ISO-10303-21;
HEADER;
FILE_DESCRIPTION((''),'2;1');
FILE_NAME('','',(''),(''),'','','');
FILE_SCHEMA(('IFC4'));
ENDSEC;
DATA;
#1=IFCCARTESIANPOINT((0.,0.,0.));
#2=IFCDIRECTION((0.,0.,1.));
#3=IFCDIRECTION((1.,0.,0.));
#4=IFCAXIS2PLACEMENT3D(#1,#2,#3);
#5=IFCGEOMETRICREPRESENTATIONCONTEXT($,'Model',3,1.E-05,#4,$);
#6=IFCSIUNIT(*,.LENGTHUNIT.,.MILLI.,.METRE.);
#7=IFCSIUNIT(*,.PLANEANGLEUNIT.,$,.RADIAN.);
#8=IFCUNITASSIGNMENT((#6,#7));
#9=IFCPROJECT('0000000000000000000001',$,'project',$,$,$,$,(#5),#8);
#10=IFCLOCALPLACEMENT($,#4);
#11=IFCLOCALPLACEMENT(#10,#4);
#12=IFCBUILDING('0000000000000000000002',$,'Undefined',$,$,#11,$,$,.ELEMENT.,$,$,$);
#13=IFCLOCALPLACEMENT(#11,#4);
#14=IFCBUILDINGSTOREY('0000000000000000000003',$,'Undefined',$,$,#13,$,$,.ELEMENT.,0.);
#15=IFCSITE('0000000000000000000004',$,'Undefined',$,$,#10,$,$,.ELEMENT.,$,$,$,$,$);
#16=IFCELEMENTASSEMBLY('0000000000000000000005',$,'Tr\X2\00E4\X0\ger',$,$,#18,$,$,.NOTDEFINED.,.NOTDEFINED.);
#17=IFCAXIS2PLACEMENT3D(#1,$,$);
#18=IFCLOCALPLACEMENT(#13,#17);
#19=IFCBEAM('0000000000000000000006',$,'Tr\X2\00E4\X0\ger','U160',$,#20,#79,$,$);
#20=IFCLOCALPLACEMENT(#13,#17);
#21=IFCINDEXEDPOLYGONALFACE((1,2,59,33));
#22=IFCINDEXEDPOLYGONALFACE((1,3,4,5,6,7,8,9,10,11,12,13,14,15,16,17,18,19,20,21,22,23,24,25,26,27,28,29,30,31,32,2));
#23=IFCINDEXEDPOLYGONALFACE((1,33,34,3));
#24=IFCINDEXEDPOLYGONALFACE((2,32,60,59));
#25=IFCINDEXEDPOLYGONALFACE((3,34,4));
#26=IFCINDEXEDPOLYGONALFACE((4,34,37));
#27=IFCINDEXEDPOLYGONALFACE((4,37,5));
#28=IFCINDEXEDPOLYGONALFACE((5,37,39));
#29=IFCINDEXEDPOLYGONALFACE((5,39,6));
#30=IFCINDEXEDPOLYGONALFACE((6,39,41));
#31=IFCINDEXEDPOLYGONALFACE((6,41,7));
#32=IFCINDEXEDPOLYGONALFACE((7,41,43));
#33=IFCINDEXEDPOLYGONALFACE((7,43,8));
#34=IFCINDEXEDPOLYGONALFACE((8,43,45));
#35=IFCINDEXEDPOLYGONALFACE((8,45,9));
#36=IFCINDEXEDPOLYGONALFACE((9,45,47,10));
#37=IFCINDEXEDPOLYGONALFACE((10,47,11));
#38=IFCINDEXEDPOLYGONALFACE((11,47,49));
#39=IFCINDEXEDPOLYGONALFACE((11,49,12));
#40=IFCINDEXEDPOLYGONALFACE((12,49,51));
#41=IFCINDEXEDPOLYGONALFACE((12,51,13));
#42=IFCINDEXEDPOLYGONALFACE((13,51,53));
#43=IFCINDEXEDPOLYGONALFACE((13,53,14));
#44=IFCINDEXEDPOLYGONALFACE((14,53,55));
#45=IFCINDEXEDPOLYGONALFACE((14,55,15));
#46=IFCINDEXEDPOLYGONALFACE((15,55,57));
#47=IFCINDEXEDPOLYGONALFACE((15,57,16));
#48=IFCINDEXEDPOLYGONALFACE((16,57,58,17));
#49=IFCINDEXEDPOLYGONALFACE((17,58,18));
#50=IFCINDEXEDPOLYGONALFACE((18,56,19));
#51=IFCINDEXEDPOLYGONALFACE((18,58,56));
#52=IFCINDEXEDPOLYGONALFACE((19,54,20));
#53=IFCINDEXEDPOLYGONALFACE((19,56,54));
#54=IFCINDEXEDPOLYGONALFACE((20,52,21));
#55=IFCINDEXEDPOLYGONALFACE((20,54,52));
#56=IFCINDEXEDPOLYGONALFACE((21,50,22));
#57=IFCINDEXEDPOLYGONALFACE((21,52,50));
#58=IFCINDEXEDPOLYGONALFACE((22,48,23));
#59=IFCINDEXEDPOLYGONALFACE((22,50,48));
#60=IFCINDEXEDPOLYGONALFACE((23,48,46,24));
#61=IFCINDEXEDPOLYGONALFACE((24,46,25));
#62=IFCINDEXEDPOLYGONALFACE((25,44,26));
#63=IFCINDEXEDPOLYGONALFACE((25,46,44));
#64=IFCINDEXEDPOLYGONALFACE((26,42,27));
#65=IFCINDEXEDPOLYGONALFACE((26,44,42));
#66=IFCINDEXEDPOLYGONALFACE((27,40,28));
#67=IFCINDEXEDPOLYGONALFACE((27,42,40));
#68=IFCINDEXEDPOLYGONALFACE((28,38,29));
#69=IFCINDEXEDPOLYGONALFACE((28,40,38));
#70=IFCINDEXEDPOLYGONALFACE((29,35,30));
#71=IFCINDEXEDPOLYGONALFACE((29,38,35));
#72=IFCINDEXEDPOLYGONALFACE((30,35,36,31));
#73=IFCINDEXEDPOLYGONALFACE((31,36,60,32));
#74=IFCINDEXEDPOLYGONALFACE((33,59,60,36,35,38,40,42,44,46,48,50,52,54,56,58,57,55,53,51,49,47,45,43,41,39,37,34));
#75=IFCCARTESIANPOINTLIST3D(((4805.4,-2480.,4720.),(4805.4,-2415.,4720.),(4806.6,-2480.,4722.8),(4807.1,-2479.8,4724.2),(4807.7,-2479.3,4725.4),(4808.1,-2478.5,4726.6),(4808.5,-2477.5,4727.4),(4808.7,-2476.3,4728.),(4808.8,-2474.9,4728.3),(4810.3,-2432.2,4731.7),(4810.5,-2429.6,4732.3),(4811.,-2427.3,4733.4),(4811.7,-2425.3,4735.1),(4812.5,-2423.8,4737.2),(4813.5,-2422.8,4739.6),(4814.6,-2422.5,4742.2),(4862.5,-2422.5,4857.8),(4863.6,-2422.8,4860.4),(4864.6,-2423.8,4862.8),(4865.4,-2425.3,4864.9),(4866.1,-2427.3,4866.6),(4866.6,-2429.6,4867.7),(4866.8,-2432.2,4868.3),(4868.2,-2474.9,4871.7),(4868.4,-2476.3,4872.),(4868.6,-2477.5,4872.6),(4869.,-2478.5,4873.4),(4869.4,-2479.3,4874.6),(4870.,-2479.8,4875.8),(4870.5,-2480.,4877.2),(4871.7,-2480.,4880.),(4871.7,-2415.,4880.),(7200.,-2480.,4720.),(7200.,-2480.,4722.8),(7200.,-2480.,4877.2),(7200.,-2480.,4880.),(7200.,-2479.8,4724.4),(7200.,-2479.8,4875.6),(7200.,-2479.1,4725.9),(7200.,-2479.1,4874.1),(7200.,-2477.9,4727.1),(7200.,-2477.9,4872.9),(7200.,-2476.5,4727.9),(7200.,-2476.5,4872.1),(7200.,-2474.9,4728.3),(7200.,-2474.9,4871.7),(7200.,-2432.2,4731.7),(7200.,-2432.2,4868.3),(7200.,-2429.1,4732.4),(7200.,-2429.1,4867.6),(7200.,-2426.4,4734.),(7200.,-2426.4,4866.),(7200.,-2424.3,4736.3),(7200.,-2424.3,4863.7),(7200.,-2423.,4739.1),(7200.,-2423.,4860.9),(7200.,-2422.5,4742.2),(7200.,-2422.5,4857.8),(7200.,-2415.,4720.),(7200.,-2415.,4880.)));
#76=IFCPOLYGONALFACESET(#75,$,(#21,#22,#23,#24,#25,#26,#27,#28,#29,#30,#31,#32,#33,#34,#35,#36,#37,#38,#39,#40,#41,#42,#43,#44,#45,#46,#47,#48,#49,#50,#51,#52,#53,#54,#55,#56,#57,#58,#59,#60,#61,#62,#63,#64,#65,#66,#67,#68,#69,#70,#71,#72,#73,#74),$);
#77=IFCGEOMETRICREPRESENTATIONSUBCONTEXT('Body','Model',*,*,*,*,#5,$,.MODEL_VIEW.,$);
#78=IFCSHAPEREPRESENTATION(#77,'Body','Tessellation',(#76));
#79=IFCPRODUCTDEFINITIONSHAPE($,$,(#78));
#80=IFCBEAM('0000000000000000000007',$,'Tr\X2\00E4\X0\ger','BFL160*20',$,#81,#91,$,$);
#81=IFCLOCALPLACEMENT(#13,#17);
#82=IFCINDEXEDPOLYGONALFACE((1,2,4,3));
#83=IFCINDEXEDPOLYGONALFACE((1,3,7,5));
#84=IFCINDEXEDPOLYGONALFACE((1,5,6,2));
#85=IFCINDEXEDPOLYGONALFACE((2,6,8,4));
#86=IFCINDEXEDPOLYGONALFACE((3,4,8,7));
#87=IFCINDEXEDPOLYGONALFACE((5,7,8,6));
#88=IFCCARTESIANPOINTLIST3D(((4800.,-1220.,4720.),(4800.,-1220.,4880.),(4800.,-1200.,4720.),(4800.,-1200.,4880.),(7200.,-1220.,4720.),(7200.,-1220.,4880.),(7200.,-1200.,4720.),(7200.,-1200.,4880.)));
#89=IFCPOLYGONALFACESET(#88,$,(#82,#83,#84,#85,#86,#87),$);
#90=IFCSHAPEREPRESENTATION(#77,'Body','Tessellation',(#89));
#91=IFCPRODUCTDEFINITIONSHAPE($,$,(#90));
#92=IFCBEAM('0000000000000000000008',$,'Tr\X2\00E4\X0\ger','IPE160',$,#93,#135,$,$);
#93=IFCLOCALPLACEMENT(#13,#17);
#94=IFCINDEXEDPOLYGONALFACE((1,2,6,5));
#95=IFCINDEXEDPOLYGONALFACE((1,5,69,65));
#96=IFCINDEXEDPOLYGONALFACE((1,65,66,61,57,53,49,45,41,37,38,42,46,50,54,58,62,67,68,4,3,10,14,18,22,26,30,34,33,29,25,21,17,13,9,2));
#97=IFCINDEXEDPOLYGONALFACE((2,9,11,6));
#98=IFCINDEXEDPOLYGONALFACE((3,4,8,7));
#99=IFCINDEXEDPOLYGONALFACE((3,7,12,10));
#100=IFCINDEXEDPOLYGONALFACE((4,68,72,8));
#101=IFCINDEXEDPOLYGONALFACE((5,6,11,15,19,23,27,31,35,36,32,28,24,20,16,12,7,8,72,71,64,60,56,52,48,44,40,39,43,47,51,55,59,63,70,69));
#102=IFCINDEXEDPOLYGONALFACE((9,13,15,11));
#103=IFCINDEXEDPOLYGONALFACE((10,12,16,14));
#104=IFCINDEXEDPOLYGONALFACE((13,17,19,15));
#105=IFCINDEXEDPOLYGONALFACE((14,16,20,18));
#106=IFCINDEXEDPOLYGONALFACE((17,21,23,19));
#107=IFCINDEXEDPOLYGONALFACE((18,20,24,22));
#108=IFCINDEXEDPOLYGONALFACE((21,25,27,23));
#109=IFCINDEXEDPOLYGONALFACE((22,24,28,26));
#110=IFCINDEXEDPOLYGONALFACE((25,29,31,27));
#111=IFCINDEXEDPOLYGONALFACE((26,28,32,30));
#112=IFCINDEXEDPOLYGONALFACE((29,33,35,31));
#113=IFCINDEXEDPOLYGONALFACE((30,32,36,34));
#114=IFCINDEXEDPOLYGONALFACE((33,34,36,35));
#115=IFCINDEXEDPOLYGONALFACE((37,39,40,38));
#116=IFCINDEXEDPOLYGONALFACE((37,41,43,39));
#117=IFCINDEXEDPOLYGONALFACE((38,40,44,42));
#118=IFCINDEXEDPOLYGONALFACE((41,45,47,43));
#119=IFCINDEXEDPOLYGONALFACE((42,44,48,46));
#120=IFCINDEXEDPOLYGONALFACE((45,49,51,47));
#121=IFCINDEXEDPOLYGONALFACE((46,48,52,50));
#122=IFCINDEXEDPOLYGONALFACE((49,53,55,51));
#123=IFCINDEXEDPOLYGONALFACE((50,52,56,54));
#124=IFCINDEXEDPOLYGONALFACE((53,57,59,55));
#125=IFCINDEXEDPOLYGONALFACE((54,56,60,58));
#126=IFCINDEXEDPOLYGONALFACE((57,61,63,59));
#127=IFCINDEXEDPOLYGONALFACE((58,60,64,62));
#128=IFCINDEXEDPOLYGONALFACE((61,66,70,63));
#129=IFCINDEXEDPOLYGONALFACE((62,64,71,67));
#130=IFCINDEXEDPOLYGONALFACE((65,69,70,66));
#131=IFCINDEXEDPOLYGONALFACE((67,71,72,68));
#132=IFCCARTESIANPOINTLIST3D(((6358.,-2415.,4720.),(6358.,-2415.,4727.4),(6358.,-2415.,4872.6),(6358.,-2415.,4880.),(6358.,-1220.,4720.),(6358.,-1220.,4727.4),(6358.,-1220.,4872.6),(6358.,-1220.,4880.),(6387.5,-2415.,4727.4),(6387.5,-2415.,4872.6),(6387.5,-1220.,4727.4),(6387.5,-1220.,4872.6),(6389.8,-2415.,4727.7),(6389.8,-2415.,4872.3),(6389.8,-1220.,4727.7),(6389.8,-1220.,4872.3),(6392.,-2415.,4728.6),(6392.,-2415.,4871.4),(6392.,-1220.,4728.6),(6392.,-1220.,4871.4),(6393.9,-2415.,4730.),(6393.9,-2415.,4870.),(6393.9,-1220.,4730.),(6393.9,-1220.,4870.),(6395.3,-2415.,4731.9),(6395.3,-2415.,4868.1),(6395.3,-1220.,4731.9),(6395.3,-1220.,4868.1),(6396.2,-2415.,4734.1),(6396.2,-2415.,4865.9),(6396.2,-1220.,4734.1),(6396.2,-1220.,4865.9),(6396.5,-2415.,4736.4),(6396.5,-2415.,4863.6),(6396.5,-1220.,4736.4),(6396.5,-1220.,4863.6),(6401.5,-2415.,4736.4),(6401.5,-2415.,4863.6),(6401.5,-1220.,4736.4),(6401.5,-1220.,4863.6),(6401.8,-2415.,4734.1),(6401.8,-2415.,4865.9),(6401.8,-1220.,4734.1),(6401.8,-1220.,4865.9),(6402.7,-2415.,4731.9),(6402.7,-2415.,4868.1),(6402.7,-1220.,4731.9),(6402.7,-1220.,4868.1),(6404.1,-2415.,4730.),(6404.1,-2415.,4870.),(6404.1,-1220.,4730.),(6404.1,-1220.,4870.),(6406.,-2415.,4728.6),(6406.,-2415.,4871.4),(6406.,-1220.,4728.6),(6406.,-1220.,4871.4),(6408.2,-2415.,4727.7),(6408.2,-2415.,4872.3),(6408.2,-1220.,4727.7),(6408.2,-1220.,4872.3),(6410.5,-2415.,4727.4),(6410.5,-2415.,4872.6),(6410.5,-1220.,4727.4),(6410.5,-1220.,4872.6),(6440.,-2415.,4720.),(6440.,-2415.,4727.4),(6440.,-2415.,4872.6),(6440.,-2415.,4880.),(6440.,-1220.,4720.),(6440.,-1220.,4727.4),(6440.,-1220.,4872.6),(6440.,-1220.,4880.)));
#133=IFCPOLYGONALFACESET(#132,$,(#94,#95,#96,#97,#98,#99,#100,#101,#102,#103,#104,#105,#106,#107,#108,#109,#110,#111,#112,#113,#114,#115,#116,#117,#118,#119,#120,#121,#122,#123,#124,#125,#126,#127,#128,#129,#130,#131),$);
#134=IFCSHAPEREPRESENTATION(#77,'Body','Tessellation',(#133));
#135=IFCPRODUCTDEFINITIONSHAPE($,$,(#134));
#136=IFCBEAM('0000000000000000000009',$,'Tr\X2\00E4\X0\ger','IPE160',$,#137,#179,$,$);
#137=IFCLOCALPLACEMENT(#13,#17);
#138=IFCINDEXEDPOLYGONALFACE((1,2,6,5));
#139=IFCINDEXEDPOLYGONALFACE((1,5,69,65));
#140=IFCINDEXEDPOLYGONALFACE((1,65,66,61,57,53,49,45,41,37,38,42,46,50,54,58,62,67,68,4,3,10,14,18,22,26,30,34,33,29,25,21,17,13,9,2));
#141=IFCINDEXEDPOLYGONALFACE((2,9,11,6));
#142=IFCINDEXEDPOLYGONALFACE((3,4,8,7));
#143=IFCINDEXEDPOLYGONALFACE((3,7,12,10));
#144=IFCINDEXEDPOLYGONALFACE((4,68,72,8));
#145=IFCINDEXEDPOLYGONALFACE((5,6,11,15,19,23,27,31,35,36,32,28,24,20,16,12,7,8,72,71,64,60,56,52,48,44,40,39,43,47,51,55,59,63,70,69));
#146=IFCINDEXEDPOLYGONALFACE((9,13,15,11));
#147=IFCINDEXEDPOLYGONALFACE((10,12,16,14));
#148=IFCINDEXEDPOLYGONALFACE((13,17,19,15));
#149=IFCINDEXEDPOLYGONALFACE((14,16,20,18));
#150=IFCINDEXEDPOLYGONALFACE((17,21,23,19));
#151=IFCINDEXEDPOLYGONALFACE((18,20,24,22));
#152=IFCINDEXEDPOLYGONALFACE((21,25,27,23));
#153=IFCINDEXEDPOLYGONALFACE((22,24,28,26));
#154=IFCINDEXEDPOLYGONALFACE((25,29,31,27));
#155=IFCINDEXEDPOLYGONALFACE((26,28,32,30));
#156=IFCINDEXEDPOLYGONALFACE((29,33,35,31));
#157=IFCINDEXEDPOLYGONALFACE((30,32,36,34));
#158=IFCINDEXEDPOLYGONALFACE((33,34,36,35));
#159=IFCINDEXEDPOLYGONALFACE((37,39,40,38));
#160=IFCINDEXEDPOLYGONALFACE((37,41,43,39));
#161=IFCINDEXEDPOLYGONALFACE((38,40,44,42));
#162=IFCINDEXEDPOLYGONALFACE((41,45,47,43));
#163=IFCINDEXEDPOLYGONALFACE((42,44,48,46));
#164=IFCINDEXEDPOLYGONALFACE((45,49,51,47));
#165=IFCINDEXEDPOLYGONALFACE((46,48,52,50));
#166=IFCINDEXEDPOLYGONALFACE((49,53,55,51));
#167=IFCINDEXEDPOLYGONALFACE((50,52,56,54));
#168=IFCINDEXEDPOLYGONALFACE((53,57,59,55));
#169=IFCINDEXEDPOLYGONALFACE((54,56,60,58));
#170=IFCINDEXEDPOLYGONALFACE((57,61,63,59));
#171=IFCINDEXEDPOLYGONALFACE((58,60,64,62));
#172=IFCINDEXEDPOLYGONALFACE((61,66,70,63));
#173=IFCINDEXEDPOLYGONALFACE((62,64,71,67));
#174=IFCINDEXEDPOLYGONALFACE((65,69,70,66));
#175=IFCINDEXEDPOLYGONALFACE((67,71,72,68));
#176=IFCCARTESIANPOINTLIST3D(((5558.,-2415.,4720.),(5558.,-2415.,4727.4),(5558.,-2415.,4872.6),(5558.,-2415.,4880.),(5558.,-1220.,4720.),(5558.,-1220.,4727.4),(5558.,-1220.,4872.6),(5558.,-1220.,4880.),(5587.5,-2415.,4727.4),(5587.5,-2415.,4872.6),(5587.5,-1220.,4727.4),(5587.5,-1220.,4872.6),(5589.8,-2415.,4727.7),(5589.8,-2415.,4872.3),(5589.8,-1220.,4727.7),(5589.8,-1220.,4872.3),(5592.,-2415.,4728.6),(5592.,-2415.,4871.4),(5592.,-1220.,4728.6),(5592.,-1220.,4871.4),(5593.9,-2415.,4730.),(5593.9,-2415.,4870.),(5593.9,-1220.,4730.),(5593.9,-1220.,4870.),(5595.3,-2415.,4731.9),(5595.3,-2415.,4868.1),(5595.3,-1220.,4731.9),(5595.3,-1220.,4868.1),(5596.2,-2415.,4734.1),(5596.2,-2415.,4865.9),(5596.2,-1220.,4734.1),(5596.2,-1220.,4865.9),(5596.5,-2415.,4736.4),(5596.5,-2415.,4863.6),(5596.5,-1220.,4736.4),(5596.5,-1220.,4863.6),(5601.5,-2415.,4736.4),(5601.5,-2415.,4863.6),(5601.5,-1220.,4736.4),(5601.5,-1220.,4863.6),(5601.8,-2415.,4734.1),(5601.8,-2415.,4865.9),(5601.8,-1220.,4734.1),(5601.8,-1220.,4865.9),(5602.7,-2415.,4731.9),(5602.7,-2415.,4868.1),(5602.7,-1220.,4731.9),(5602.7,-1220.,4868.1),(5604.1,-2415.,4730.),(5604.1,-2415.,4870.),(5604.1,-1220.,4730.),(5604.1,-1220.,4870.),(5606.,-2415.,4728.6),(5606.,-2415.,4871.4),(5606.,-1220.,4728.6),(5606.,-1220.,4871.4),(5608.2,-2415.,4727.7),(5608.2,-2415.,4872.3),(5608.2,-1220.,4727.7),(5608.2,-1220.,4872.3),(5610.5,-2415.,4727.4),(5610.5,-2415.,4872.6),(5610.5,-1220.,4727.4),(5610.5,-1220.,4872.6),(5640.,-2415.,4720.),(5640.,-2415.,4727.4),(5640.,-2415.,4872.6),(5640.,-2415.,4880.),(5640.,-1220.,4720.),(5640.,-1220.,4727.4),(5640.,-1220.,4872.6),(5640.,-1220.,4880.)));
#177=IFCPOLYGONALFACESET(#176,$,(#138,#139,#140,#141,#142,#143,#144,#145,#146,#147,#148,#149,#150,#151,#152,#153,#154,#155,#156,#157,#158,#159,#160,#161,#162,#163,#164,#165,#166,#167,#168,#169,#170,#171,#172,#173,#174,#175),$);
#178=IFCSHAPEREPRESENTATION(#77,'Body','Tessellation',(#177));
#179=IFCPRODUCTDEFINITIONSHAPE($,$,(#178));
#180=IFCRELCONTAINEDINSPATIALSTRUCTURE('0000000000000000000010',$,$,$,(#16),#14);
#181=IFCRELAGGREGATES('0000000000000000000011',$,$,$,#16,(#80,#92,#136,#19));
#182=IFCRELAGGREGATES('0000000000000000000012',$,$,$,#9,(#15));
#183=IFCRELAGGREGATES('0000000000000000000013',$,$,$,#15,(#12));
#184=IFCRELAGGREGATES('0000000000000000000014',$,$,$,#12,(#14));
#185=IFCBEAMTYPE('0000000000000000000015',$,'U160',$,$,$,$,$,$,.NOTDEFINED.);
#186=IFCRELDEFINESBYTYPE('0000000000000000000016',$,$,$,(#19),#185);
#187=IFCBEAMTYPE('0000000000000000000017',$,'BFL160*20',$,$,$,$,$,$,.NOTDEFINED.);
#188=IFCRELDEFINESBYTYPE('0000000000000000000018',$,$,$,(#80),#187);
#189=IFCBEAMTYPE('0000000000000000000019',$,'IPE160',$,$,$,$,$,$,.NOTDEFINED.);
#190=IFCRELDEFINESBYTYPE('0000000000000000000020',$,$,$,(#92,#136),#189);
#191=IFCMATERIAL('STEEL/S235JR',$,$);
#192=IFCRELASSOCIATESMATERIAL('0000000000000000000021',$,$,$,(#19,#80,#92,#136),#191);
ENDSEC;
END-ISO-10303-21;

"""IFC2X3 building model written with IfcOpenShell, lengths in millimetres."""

from ifc_helpers import new_model, si_unit, frame, origin_with_axes, origin_2d_with_axis, place, context, subcontext, project, spatial, rectangle, i_section, u_section, extrude, clip, halfspace, material, type_object, element, aggregate, save


model = new_model("IFC2X3")

# Units and contexts
model_context = context("Model", 3, precision=1e-05, world=origin_with_axes())
body_context = subcontext(model_context, "Body", "Model", "MODEL_VIEW")
ifc_project = project(units=[si_unit("LENGTHUNIT", "METRE", prefix="MILLI"), si_unit("PLANEANGLEUNIT", "RADIAN")], contexts=[model_context])

# Site, building, storey
site_placement = place(None, origin_with_axes())
site = spatial("IfcSite", under=ifc_project, at=site_placement, Name="Undefined", CompositionType="ELEMENT")
building_placement = place(site_placement, origin_with_axes())
building = spatial("IfcBuilding", under=site, at=building_placement, Name="Undefined", CompositionType="ELEMENT")
storey_placement = place(building_placement, origin_with_axes())
storey = spatial("IfcBuildingStorey", under=building, at=storey_placement, Name="Undefined", CompositionType="ELEMENT", Elevation=0.0)

# Element assembly, beams
assembly_placement = place(storey_placement, origin_with_axes())
assembly = element("IfcElementAssembly", 1, at=assembly_placement, inside=storey, Name="Träger", AssemblyPlace="NOTDEFINED", PredefinedType="NOTDEFINED")
ifc_material_1 = material(Name="STEEL/S235JR")
beam_type_1 = type_object("IfcBeamType", Name="U160", PredefinedType="NOTDEFINED")
beam_1_placement = place(assembly_placement, frame((4866.3, -2447.5, 4800.0), z_axis=(0.0, 0.0, 1.0), x_axis=(1.0, 0.0, 0.0)))
beam_1 = element("IfcBeam", 2, at=beam_1_placement, type_object=beam_type_1, material=ifc_material_1, Name="Träger", Description="U160", context=body_context, shape_type="Clipping", body=[
    clip(extrude(u_section(Depth=160.0, FlangeWidth=65.0, WebThickness=7.5, FlangeThickness=10.5, FilletRadius=10.5, EdgeRadius=5.5, FlangeSlope=0.07983, at=origin_2d_with_axis()), frame((2333.7, 0.0, 0.0), z_axis=(-1.0, 0.0, 0.0), x_axis=(0.0, -1.0, 0.0)), (0.0, 0.0, 1.0), 2394.9), halfspace(frame((4.6, 0.0, 78.1), z_axis=(0.92388, 0.0, -0.382683), x_axis=(0.0, 1.0, 0.0)), True)),
])
beam_type_2 = type_object("IfcBeamType", Name="BFL160*20", PredefinedType="NOTDEFINED")
beam_2_placement = place(assembly_placement, frame((4800.0, -1210.0, 4800.0), z_axis=(0.0, 0.0, 1.0), x_axis=(1.0, 0.0, 0.0)))
beam_2 = element("IfcBeam", 3, at=beam_2_placement, type_object=beam_type_2, material=ifc_material_1, Name="Träger", Description="BFL160*20", context=body_context, shape_type="SweptSolid", body=[
    extrude(rectangle(XDim=20.0, YDim=160.0, at=origin_2d_with_axis()), frame((2400.0, 0.0, 0.0), z_axis=(-1.0, 0.0, 0.0), x_axis=(0.0, -1.0, 0.0)), (0.0, 0.0, 1.0), 2400.0),
])
beam_type_3 = type_object("IfcBeamType", Name="IPE160", PredefinedType="NOTDEFINED")
beam_3_placement = place(assembly_placement, frame((6399.0, -1220.0, 4800.0), z_axis=(0.0, 0.0, -1.0), x_axis=(0.0, -1.0, 0.0)))
beam_3 = element("IfcBeam", 4, at=beam_3_placement, type_object=beam_type_3, material=ifc_material_1, Name="Träger", Description="IPE160", context=body_context, shape_type="SweptSolid", body=[
    extrude(i_section(OverallWidth=82.0, OverallDepth=160.0, WebThickness=5.0, FlangeThickness=7.4, FilletRadius=9.0, at=origin_2d_with_axis()), frame((1195.0, 0.0, 0.0), z_axis=(-1.0, 0.0, 0.0), x_axis=(0.0, -1.0, 0.0)), (0.0, 0.0, 1.0), 1195.0),
])
beam_4_placement = place(assembly_placement, frame((5599.0, -1220.0, 4800.0), z_axis=(0.0, 0.0, -1.0), x_axis=(0.0, -1.0, 0.0)))
beam_4 = element("IfcBeam", 5, at=beam_4_placement, type_object=beam_type_3, material=ifc_material_1, Name="Träger", Description="IPE160", context=body_context, shape_type="SweptSolid", body=[
    extrude(i_section(OverallWidth=82.0, OverallDepth=160.0, WebThickness=5.0, FlangeThickness=7.4, FilletRadius=9.0, at=origin_2d_with_axis()), frame((1195.0, 0.0, 0.0), z_axis=(-1.0, 0.0, 0.0), x_axis=(0.0, -1.0, 0.0)), (0.0, 0.0, 1.0), 1195.0),
])
aggregate(assembly, [beam_2, beam_3, beam_4, beam_1])

save(model, "model.ifc")
